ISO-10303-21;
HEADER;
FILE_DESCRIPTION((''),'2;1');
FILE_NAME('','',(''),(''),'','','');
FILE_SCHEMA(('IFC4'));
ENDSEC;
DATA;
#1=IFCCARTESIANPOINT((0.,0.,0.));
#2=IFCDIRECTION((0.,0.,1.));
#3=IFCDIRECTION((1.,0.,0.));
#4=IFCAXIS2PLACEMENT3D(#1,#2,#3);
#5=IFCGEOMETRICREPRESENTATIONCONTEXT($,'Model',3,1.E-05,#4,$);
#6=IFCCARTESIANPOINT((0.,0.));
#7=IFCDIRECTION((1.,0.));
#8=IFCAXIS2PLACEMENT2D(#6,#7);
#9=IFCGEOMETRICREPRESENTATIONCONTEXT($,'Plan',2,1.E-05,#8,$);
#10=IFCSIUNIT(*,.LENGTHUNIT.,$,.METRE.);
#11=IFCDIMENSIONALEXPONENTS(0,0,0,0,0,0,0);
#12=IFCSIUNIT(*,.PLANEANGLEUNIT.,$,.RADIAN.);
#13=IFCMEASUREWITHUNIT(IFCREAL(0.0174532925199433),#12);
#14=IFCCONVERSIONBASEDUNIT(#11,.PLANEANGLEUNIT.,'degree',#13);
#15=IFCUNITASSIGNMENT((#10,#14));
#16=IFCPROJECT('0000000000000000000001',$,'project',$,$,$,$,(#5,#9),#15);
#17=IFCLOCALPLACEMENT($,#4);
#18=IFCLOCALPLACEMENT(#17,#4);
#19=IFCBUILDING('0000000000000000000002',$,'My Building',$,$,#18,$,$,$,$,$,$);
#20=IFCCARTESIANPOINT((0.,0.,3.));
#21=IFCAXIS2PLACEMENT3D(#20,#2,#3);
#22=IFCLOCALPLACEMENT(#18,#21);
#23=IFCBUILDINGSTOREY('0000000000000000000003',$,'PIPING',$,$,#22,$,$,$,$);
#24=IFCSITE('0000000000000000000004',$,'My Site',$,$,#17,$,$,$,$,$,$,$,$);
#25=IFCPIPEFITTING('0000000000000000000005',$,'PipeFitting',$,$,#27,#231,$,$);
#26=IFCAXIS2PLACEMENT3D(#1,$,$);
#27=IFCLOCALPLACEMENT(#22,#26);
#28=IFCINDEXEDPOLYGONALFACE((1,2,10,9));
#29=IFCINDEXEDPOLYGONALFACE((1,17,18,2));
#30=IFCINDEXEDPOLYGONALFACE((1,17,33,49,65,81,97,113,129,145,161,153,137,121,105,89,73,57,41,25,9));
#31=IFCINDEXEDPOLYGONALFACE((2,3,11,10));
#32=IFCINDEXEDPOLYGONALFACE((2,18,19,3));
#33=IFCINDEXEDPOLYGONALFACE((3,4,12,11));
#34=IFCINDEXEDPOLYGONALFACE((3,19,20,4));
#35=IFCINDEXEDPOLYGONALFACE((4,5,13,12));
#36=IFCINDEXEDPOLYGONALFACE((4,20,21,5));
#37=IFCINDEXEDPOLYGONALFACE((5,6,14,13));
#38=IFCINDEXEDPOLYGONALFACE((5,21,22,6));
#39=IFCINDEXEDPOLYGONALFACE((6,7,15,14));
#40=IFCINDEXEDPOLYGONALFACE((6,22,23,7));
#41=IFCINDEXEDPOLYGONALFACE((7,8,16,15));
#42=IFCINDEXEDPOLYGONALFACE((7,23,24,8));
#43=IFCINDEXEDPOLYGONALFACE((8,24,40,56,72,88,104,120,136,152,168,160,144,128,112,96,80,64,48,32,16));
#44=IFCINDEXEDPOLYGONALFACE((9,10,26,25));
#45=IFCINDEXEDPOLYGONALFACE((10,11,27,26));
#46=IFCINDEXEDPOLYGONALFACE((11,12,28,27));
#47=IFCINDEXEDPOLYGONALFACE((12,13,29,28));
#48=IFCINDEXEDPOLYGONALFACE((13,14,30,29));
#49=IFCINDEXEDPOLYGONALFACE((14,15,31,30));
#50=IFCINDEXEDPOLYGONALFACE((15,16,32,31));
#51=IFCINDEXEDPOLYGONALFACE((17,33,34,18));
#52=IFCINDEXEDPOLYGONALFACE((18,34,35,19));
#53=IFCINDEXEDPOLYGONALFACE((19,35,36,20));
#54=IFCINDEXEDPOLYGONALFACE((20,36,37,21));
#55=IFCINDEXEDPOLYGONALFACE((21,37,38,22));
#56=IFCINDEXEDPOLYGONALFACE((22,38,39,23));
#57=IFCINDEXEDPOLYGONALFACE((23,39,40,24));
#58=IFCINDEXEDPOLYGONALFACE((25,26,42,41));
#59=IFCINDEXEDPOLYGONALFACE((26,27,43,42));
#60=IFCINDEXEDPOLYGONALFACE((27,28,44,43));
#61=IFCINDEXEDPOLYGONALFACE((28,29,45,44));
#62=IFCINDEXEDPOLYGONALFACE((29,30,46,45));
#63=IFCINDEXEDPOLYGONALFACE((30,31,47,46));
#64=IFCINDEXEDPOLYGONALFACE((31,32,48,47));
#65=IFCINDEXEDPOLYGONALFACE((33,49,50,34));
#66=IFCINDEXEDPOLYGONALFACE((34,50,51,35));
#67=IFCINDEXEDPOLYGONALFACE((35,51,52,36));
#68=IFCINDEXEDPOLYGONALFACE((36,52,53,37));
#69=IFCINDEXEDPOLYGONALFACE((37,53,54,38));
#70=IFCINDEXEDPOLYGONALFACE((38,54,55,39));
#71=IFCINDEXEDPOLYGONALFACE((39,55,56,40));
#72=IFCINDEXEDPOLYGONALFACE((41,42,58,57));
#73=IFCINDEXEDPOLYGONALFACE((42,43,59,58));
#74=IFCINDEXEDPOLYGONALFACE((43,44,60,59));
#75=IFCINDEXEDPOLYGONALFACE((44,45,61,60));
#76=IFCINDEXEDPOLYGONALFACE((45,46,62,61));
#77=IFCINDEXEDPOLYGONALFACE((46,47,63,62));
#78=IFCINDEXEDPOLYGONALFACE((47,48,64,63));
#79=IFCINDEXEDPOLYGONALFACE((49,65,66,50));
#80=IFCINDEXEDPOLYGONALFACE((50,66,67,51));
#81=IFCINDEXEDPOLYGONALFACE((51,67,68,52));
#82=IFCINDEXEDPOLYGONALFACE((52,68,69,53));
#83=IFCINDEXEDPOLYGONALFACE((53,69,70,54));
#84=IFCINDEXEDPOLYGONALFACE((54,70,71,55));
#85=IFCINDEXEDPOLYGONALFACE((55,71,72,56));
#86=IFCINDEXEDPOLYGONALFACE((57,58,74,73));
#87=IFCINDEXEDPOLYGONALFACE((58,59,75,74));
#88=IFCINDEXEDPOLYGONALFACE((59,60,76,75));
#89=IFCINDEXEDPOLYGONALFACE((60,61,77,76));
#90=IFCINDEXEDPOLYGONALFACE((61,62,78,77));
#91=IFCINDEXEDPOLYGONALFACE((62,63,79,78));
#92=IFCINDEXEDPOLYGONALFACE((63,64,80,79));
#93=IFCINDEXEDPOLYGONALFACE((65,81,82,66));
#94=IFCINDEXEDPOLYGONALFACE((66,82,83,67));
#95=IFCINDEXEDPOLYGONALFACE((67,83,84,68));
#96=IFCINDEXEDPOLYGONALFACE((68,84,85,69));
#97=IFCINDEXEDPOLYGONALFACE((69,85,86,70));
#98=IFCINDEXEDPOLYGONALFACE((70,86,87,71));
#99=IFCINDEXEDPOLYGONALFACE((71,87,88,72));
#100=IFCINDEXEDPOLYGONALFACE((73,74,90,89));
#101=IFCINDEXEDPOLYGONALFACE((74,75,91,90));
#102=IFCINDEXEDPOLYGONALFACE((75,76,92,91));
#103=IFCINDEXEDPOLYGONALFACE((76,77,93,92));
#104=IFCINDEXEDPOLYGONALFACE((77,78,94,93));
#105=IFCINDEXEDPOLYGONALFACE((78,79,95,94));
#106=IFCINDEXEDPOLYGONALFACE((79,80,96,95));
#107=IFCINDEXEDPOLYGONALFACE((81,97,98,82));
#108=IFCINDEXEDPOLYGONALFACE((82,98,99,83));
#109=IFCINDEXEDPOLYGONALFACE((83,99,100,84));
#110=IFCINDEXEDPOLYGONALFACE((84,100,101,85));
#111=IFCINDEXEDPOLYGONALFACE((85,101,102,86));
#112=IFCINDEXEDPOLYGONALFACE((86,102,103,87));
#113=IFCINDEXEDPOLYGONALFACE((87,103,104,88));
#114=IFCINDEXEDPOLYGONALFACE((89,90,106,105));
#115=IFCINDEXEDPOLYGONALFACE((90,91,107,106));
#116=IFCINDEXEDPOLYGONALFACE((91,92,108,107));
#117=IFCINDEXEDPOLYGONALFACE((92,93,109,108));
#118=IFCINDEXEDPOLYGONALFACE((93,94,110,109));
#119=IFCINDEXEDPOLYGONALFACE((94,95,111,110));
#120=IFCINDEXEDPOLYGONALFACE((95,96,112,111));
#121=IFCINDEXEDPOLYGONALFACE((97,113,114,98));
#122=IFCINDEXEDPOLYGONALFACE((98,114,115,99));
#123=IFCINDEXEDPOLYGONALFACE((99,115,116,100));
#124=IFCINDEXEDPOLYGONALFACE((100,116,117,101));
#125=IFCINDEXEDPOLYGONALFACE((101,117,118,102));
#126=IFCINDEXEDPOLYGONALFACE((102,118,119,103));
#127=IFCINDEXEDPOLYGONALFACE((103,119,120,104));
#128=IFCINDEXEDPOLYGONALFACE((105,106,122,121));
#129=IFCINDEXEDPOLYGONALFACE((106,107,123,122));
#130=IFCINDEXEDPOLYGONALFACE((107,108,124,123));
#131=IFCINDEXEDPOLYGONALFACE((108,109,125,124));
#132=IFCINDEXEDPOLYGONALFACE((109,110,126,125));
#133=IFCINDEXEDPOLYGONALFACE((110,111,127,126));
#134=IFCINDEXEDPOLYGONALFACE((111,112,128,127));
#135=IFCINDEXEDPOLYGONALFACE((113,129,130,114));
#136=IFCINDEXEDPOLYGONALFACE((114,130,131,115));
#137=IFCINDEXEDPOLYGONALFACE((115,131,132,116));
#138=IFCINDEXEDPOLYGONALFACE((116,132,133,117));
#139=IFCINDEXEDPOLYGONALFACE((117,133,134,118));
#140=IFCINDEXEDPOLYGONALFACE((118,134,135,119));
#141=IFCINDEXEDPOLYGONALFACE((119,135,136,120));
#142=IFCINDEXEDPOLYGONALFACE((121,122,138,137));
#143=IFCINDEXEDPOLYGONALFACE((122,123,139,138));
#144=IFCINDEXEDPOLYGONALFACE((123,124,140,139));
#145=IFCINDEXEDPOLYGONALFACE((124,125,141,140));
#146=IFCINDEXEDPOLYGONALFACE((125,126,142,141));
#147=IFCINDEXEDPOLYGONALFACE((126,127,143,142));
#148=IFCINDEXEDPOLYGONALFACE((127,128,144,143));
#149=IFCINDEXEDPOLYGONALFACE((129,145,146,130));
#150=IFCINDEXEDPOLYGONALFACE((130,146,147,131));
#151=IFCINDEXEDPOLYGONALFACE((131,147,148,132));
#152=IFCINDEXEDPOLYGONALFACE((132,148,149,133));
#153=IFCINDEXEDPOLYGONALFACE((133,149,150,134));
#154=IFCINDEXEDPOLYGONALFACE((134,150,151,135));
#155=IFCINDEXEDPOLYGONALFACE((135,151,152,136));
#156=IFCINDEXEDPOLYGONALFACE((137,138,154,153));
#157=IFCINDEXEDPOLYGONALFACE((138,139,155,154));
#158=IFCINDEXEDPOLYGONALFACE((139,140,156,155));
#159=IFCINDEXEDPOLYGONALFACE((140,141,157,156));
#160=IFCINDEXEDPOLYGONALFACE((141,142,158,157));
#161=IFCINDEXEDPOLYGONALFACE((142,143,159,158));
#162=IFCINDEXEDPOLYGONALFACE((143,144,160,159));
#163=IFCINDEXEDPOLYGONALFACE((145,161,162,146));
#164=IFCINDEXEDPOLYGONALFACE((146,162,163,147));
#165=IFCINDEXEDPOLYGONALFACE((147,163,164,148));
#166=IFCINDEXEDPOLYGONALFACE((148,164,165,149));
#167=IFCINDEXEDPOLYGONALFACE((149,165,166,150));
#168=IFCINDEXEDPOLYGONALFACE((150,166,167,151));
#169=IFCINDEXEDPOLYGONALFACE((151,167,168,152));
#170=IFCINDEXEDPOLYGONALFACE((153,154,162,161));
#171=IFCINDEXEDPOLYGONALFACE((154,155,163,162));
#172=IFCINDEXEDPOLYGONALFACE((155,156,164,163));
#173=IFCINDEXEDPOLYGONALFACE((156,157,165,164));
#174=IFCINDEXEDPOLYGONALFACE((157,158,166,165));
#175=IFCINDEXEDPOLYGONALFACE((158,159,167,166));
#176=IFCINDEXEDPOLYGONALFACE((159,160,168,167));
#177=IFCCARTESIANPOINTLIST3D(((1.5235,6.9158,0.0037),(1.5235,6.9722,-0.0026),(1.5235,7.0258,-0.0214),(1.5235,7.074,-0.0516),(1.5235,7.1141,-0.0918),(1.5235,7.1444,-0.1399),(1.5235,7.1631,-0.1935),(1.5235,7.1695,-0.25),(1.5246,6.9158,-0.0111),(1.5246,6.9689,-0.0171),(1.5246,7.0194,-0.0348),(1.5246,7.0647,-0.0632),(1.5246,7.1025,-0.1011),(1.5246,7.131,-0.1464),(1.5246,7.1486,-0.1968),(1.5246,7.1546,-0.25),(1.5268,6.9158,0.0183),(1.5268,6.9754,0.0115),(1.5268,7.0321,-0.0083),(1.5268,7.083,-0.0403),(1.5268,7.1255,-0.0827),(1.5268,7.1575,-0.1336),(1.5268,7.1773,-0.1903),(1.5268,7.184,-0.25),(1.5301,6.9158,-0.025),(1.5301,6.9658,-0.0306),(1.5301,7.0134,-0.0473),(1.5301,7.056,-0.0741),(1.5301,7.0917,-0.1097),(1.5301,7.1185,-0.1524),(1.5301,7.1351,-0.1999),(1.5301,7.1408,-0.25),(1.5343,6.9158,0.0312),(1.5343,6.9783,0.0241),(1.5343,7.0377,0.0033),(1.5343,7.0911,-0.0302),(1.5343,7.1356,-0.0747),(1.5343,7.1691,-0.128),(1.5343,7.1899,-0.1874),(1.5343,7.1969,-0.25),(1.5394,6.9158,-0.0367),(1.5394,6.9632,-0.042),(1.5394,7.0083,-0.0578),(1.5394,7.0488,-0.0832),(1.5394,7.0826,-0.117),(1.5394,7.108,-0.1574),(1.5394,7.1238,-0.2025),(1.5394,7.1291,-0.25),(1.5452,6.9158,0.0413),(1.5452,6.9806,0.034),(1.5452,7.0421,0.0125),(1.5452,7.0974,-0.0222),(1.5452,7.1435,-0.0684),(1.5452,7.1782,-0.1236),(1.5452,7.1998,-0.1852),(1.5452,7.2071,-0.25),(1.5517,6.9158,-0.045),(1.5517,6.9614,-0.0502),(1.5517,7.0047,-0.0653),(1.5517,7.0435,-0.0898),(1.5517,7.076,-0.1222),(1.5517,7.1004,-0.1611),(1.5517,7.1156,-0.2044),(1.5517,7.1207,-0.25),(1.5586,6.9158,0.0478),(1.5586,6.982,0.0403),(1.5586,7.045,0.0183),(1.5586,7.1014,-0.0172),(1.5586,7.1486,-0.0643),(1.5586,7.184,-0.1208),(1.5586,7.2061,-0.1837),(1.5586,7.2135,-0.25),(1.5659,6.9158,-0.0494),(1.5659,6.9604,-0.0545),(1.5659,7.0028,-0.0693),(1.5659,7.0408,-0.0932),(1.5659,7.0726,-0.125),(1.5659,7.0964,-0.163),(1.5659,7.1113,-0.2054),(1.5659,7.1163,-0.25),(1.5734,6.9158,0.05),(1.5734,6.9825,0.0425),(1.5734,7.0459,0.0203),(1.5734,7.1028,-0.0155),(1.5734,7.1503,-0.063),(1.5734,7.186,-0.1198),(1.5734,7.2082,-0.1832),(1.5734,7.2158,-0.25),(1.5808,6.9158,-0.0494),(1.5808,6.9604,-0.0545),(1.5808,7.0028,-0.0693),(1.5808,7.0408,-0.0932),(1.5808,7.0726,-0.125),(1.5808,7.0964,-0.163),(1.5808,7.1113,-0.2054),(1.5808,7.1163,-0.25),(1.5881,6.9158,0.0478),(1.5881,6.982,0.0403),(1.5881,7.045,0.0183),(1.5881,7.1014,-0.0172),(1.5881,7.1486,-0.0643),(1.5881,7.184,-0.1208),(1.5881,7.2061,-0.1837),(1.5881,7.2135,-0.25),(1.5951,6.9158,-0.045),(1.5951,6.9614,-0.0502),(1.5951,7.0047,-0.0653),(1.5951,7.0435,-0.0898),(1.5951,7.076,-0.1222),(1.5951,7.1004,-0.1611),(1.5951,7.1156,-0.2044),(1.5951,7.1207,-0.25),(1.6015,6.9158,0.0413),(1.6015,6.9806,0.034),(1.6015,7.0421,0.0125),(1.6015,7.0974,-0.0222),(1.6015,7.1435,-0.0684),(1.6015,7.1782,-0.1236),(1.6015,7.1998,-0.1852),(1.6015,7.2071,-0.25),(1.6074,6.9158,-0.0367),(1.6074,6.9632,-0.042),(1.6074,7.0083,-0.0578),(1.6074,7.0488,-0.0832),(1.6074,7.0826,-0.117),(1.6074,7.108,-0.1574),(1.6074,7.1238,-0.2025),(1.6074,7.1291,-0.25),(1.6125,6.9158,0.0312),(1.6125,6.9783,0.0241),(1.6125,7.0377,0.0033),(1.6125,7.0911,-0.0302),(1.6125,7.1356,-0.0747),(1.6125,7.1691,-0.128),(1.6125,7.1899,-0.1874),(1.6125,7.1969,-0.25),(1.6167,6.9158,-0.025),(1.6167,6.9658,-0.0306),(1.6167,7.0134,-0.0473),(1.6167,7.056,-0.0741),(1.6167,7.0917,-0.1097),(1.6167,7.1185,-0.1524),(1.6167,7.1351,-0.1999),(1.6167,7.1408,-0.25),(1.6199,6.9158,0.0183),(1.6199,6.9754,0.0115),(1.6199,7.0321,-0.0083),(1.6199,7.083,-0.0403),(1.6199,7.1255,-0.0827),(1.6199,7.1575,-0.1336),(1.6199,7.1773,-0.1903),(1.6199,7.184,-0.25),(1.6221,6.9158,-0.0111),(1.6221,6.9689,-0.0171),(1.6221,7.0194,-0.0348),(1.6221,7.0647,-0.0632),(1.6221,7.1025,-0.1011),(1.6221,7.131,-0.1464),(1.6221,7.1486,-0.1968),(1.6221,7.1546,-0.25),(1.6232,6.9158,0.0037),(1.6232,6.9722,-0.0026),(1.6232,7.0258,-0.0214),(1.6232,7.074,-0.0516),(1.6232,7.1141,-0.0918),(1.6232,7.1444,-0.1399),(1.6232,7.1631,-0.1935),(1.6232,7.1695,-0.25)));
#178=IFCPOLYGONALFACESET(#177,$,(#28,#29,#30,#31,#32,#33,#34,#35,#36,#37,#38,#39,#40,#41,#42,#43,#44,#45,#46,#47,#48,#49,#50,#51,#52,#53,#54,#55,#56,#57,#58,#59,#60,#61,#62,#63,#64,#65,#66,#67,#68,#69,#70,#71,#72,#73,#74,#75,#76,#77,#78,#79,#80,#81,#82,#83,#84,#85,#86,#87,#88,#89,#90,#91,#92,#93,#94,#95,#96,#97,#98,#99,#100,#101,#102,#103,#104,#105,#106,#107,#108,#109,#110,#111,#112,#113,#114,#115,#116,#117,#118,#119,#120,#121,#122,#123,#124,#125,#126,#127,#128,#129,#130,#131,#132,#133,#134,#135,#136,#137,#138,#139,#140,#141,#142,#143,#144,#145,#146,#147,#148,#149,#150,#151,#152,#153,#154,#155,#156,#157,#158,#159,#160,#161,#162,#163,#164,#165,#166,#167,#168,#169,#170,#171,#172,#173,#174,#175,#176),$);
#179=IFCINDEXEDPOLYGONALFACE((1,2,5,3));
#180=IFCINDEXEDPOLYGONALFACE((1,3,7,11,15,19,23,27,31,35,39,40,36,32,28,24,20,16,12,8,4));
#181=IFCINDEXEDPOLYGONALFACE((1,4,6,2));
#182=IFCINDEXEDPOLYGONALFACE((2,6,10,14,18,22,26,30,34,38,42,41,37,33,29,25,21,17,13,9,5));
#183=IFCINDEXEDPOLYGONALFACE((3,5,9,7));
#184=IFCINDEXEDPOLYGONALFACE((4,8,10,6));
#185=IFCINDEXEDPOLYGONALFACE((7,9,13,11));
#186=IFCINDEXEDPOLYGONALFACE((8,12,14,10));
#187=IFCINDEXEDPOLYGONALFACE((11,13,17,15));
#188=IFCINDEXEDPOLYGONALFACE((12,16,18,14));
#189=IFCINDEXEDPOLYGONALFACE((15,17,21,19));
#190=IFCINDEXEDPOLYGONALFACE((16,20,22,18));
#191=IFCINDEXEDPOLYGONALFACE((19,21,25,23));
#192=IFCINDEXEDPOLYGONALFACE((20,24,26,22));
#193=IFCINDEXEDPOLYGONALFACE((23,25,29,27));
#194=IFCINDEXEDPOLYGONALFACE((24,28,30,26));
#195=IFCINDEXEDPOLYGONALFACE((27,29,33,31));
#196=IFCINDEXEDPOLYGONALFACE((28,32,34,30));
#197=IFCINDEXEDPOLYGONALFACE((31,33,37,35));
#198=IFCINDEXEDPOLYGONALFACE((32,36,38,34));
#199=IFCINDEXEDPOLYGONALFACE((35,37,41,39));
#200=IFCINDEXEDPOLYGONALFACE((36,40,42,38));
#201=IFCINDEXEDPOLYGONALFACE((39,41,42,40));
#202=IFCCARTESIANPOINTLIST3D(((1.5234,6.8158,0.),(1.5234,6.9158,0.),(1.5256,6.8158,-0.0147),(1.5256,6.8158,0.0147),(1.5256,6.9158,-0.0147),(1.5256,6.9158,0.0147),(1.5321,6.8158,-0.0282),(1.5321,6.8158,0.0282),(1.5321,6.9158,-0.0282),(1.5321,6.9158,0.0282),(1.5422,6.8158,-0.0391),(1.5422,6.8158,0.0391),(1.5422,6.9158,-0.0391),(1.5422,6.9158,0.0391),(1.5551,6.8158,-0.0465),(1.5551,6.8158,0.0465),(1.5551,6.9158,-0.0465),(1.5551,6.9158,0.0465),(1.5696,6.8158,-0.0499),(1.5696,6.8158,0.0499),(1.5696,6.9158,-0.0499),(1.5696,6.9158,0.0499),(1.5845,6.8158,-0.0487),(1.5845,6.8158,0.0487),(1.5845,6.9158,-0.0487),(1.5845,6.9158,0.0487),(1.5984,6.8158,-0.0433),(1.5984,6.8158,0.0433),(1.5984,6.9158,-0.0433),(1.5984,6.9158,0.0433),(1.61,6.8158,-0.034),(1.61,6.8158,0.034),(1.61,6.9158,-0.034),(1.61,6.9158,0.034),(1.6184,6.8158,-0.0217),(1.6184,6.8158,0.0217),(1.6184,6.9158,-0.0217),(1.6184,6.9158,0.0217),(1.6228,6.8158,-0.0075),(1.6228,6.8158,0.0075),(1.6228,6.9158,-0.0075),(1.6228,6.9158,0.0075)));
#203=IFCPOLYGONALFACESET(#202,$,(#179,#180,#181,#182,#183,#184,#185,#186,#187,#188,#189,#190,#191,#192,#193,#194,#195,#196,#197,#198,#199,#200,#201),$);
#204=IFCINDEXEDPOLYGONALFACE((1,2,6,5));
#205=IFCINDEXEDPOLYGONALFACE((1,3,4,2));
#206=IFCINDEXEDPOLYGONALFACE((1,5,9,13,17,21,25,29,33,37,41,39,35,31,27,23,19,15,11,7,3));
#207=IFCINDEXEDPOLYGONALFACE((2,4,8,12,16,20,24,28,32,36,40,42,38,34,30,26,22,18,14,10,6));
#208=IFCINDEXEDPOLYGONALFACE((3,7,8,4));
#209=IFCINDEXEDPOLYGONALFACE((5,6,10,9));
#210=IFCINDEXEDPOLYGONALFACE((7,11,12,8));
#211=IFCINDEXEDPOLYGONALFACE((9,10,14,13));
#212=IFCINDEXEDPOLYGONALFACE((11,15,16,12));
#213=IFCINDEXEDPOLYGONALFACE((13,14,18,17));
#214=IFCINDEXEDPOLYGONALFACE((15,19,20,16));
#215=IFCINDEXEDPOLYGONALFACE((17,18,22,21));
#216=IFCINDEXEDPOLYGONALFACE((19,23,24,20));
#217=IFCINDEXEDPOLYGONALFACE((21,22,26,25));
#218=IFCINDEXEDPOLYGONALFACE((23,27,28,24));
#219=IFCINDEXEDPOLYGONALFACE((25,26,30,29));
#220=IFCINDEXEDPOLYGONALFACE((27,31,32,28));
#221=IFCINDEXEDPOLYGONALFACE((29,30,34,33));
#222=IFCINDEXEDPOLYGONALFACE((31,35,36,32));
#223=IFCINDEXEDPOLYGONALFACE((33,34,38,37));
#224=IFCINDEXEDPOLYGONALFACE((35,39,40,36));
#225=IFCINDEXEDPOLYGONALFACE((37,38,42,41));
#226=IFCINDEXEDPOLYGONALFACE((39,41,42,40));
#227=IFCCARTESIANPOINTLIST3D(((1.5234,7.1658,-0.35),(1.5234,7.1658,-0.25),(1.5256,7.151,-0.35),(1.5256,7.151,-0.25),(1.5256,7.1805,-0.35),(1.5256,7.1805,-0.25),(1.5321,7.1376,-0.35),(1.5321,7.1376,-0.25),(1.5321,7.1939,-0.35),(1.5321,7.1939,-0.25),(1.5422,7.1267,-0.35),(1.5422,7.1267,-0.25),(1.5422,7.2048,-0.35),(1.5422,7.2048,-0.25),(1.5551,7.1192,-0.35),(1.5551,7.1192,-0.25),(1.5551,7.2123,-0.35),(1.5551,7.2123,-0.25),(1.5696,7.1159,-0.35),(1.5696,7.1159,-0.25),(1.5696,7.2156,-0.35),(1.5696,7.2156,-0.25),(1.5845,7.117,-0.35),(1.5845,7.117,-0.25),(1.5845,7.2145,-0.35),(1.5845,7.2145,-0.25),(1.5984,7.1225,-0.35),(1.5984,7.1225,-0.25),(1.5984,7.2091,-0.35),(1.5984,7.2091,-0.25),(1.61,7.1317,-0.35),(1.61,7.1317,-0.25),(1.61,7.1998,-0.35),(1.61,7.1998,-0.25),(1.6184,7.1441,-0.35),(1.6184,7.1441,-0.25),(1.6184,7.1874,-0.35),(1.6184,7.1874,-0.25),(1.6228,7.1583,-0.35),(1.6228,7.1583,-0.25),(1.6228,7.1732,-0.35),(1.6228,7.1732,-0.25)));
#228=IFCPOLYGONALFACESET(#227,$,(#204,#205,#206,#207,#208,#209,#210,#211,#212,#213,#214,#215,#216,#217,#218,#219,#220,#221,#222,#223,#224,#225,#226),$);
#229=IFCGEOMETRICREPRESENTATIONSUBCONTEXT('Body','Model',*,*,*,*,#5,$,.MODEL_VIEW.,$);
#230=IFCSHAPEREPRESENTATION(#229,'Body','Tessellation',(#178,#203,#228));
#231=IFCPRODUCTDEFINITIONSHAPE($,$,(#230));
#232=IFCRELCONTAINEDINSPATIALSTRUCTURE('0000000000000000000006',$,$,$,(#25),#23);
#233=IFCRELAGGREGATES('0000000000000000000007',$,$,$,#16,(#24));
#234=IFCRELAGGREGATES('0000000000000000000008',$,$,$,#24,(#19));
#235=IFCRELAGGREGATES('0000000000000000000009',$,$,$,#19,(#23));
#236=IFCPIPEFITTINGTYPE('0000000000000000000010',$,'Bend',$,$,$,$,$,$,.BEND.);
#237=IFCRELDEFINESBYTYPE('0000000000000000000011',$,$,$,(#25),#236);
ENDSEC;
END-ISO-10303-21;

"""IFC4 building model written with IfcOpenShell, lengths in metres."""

from ifc_helpers import new_model, entity, si_unit, converted_unit, frame, origin_with_axes, origin_2d_with_axis, place, context, subcontext, project, spatial, circle, extrude, source, transform, mapped, type_object, type_shapes, element, save


model = new_model("IFC4")

# Units and contexts
model_context = context("Model", 3, precision=1e-05, world=origin_with_axes())
plan_context = context("Plan", 2, precision=1e-05, world=origin_2d_with_axis())
body_context = subcontext(model_context, "Body", "Model", "MODEL_VIEW")
ifc_project = project(units=[si_unit("LENGTHUNIT", "METRE"), converted_unit("PLANEANGLEUNIT", "degree", entity("IfcReal", 0.0174532925199433), si_unit("PLANEANGLEUNIT", "RADIAN"), dimensions=[0, 0, 0, 0, 0, 0, 0])], contexts=[model_context, plan_context])

# Site, building, storey
site_placement = place(None, origin_with_axes())
site = spatial("IfcSite", under=ifc_project, at=site_placement, Name="My Site")
building_placement = place(site_placement, origin_with_axes())
building = spatial("IfcBuilding", under=site, at=building_placement, Name="My Building")
storey_placement = place(building_placement, frame((0.0, 0.0, 3.0), z_axis=(0.0, 0.0, 1.0), x_axis=(1.0, 0.0, 0.0)))
storey = spatial("IfcBuildingStorey", under=building, at=storey_placement, Name="PIPING")

# Pipe fitting
pipe_fitting_type = type_object("IfcPipeFittingType", Name="Bend", PredefinedType="BEND")
shared_shape = source(origin_with_axes(), body_context, "Body", "SolidModel", [
    entity("IfcSweptDiskSolid", entity("IfcIndexedPolyCurve", entity("IfcCartesianPointList3D", [[0.0, 0.0, 0.1], [0.0, -0.0732, 0.2768], [0.0, -0.25, 0.35]]), [entity("IfcArcIndex", [1, 2, 3])]), 0.05),
    extrude(circle(Radius=0.05), origin_with_axes(), (0.0, 0.0, 1.0), 0.1),
    extrude(circle(Radius=0.05), frame((0.0, -0.25, 0.35), z_axis=(0.0, -1.0, 0.0), x_axis=(1.0, 0.0, 0.0)), (0.0, 0.0, 1.0), 0.1),
])
type_shapes(pipe_fitting_type, [shared_shape])
for number, where, z_axis, x_axis, name in (
    (1, (1.5734, 6.8158, 0.0), (0.0, 1.0, 0.0), (-1.0, 0.0, 0.0), "PipeFitting"),
):
    element("IfcPipeFitting", number, at=place(storey_placement, frame(where, z_axis=z_axis, x_axis=x_axis)), inside=storey, type_object=pipe_fitting_type, Name=name, context=body_context, shape_type="MappedRepresentation", body=[
        mapped(shared_shape, transform((0.0, 0.0, 0.0), x_axis=(1.0, 0.0, 0.0), y_axis=(0.0, 1.0, 0.0), z_axis=(0.0, 0.0, 1.0), scale=1.0)),
    ])

save(model, "model.ifc")
